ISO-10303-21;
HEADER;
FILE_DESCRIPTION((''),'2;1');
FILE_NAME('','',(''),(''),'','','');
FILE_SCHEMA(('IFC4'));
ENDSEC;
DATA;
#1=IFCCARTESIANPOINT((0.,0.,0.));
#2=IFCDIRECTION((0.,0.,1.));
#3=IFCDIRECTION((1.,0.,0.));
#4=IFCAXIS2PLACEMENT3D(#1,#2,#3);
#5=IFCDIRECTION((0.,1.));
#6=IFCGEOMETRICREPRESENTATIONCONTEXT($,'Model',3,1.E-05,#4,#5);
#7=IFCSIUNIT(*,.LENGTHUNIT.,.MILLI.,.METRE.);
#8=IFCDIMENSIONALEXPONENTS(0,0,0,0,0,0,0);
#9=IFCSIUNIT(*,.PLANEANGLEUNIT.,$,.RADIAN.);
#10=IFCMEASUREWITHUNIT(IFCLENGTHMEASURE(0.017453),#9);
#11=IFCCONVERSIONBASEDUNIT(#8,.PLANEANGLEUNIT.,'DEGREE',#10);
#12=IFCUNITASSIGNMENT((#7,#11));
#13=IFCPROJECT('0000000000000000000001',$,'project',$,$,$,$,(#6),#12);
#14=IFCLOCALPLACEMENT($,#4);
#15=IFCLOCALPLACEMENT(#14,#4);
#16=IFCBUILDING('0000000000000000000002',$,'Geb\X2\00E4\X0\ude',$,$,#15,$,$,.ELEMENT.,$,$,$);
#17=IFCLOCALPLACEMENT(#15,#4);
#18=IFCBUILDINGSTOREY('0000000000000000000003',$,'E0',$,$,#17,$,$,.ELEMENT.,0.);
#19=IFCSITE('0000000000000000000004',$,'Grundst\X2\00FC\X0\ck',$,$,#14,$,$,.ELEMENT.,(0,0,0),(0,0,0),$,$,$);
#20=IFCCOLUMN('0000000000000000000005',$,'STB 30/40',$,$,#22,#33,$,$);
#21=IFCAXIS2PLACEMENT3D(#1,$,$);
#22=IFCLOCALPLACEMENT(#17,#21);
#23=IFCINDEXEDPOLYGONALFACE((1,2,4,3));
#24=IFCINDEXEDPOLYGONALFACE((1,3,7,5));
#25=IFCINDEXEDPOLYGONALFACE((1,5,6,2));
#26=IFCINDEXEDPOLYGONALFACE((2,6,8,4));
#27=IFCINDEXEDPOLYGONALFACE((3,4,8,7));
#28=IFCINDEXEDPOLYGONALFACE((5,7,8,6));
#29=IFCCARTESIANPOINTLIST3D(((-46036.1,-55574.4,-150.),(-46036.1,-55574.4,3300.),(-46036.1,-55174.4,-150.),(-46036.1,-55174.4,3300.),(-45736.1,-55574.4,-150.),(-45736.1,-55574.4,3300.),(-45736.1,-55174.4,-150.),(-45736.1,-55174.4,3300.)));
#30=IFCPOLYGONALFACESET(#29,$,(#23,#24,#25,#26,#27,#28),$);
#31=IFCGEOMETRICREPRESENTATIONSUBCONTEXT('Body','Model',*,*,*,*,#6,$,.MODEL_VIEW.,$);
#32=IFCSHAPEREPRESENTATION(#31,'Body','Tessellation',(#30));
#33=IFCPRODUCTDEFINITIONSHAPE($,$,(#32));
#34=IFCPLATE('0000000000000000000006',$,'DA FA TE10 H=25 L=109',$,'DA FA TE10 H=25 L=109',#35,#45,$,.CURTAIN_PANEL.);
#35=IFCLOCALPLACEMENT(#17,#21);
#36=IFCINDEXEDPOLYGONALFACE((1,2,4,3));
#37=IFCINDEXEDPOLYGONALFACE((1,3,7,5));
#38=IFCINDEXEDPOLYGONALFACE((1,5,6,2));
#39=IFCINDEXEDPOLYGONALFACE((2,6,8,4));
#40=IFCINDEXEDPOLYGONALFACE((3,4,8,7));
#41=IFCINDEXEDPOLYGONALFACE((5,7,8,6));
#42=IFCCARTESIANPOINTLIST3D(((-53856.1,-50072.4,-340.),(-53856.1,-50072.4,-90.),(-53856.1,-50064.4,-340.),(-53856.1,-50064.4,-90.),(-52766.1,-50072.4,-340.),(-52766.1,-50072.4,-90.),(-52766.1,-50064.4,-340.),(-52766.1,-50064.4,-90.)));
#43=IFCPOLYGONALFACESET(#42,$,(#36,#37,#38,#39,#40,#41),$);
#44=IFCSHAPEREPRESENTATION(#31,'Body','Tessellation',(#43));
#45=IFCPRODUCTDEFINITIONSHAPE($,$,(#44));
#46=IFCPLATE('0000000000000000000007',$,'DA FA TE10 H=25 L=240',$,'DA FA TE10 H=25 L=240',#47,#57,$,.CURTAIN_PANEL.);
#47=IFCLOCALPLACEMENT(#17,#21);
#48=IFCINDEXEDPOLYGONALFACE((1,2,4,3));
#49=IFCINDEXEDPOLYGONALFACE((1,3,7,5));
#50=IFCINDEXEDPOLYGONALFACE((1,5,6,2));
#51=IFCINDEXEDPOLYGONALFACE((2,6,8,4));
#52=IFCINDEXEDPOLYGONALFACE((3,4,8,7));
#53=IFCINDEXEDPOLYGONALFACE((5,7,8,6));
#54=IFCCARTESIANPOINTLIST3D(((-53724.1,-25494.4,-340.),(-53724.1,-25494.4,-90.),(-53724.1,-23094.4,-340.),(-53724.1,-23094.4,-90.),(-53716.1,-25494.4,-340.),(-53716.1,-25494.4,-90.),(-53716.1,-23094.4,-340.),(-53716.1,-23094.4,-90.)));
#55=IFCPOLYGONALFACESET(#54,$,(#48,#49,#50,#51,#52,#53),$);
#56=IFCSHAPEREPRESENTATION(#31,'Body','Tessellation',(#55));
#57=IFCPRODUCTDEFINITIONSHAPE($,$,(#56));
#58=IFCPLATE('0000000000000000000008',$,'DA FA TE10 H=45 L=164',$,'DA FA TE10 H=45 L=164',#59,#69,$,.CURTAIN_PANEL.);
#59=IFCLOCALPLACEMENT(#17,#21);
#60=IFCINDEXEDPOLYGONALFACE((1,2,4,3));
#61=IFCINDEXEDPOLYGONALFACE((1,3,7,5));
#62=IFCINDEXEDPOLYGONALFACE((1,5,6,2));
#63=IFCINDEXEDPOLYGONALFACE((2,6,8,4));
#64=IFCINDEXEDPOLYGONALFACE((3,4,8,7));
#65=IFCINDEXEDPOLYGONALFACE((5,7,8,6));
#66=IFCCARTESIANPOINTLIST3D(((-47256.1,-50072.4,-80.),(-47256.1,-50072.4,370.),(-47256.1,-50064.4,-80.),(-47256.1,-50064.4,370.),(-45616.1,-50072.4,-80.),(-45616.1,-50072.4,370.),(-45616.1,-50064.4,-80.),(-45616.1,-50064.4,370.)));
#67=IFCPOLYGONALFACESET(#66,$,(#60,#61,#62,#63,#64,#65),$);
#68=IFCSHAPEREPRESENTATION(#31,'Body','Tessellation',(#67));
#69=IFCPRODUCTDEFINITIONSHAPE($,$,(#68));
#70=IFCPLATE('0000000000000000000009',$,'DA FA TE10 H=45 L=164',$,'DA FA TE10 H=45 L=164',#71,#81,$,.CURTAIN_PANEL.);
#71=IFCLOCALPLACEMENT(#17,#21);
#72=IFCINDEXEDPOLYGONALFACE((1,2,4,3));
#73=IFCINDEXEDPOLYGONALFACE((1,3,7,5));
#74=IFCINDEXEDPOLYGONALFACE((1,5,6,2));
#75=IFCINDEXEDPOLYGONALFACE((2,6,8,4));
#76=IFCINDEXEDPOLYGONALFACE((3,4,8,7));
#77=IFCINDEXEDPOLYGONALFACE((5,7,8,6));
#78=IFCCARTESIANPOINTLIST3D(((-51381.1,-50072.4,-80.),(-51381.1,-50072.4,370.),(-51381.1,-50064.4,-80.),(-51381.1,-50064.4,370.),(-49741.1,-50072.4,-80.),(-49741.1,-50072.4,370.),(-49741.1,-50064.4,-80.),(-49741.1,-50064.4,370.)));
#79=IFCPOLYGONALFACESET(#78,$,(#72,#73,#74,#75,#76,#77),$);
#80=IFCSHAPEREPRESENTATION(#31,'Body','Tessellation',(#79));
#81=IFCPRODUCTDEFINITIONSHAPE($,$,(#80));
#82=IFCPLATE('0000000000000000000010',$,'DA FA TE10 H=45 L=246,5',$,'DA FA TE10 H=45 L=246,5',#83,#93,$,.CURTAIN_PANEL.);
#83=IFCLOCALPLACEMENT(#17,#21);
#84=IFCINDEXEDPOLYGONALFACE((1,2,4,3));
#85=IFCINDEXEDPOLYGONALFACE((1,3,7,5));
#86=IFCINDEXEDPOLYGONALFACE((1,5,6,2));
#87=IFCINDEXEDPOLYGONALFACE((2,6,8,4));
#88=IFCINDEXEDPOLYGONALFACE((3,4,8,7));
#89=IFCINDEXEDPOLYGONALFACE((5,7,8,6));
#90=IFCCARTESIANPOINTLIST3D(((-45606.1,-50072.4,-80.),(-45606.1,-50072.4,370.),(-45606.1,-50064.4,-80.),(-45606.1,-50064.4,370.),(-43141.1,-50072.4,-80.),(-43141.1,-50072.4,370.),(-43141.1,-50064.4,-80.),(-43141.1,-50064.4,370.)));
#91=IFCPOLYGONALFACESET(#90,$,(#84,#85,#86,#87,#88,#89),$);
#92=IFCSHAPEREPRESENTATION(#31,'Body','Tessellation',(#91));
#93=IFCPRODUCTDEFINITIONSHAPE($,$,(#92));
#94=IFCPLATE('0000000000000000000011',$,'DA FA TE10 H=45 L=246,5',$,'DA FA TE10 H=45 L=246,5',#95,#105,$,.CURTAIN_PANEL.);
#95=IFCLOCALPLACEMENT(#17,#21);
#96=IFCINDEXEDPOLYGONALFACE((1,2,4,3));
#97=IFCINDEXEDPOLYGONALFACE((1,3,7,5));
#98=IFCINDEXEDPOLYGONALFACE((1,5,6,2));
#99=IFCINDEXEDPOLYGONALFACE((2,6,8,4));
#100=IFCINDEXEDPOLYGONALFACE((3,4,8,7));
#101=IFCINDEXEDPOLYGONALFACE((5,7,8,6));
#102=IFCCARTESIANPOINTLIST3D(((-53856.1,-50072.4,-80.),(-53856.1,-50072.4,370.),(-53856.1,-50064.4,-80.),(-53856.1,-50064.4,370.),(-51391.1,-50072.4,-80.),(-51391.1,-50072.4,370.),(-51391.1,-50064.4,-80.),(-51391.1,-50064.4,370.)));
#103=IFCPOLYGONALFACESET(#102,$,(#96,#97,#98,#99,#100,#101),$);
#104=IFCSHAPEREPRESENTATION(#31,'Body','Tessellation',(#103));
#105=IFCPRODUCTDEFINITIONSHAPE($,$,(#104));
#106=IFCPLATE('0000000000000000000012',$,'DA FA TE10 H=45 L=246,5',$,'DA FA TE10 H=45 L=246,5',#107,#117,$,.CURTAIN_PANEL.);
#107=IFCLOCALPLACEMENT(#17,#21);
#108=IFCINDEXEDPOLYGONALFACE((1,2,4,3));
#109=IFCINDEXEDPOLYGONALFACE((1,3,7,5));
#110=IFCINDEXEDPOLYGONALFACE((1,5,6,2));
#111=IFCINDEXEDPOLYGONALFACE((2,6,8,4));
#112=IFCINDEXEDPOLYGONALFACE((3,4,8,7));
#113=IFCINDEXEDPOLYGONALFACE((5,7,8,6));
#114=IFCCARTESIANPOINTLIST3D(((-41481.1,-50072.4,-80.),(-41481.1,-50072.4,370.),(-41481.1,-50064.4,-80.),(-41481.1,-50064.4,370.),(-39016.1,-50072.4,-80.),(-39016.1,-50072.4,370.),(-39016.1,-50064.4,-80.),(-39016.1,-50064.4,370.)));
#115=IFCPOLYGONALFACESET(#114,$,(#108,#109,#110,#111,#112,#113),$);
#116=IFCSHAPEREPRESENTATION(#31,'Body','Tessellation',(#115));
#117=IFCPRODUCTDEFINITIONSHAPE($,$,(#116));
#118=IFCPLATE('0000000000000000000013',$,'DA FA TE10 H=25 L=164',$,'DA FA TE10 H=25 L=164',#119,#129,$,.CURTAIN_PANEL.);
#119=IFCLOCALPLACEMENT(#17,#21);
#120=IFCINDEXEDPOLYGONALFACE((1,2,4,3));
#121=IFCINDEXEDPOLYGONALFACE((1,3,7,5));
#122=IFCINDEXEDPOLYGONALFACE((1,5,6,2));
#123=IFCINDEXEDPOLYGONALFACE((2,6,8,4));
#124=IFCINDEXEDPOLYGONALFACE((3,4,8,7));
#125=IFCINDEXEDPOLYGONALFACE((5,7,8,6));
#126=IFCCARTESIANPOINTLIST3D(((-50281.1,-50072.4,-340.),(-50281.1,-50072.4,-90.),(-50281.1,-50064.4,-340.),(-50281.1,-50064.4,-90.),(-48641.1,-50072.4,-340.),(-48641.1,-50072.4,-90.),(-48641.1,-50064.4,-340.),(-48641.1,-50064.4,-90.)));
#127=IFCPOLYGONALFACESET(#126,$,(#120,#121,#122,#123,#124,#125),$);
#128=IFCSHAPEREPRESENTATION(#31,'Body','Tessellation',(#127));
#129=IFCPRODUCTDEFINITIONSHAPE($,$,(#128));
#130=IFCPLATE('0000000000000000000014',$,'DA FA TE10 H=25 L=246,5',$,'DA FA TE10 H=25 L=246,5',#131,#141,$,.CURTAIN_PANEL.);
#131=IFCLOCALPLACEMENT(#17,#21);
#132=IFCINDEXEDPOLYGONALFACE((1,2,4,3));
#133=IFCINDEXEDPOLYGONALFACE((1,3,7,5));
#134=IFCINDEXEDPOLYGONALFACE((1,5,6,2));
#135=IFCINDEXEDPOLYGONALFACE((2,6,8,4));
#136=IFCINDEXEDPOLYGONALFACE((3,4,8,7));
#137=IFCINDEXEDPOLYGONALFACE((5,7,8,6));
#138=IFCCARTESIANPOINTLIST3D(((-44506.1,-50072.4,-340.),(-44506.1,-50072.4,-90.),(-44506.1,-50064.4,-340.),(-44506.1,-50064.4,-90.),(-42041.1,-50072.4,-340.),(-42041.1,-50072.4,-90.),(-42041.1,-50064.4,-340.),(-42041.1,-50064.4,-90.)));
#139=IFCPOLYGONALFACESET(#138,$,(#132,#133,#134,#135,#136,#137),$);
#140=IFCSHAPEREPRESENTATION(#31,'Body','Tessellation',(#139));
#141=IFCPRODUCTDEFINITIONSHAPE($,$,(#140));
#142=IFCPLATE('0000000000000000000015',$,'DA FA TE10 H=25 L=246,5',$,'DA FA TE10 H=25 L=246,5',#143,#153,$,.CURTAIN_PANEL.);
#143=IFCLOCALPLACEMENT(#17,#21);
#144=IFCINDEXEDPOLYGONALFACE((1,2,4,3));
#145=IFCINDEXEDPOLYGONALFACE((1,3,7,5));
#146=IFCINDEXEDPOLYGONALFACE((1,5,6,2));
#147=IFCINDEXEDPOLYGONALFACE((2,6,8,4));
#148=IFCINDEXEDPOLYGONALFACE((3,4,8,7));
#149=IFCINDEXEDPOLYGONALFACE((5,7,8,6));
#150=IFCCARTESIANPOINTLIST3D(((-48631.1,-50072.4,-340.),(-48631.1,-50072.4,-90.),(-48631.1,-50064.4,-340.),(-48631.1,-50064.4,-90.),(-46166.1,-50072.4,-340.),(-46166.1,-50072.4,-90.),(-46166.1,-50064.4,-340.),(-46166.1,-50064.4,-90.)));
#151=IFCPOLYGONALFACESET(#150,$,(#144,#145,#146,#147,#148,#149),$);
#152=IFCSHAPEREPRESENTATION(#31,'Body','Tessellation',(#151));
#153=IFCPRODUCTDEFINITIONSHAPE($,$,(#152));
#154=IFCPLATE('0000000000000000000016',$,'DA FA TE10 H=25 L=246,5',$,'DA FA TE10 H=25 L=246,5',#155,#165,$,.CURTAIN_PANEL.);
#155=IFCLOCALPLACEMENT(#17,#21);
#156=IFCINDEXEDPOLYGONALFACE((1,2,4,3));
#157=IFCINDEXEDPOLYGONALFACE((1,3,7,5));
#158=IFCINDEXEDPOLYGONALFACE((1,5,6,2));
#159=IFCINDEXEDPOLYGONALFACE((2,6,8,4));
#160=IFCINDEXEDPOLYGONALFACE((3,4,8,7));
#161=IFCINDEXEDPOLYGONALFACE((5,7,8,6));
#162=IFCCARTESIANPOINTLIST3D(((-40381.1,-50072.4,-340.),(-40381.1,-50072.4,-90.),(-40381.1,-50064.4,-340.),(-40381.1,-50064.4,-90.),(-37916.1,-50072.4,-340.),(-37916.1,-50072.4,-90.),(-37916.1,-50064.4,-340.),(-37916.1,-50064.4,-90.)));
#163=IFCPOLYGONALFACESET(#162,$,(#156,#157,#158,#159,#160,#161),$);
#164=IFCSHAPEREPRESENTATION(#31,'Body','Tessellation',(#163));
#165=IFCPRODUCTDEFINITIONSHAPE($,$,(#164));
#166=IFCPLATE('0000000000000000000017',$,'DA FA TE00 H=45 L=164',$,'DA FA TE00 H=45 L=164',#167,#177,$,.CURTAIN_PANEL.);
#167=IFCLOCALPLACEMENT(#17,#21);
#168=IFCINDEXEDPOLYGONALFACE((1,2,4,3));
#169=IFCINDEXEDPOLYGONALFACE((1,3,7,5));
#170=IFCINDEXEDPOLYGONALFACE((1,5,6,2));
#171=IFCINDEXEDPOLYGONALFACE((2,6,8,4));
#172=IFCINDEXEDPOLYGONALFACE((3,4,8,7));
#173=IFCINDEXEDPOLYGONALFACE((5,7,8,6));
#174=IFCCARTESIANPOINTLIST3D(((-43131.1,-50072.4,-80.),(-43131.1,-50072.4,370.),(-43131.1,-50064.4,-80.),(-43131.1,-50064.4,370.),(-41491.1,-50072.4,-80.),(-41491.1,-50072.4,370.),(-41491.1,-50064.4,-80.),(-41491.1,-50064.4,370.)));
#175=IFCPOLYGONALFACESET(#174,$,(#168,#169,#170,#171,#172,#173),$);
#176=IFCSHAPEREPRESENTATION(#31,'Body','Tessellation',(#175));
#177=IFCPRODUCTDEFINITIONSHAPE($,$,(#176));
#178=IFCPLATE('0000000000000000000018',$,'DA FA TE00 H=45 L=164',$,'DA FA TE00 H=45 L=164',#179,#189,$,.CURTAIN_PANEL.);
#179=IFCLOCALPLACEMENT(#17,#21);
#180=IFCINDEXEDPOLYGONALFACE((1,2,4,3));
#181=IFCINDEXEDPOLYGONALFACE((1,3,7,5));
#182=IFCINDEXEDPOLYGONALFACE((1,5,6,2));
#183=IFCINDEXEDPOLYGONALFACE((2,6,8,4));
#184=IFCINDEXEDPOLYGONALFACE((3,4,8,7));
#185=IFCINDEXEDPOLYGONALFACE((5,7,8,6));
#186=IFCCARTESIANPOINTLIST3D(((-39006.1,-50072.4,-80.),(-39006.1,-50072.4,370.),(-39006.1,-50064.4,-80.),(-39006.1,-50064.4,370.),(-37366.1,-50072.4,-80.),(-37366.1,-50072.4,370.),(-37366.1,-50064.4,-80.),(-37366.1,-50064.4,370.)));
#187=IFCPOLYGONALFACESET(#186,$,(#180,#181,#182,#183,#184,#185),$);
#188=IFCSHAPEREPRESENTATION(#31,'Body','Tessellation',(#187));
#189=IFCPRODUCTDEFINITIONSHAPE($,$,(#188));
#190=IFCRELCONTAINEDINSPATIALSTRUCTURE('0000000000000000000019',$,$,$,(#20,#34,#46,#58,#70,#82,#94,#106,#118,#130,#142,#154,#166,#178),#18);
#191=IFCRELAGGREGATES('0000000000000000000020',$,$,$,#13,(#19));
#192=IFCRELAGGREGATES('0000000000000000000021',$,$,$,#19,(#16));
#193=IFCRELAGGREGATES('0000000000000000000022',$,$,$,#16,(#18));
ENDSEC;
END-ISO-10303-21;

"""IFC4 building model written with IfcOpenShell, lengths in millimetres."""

from ifc_helpers import new_model, entity, si_unit, converted_unit, direction, frame, origin_with_axes, place, context, subcontext, project, spatial, line, indexed_curve, outline, extrude, source, transform, mapped, element, save


model = new_model("IFC4")

# Units and contexts
model_context = context("Model", 3, precision=1e-05, world=origin_with_axes(), true_north=direction((0.0, 1.0)))
body_context = subcontext(model_context, "Body", "Model", "MODEL_VIEW")
ifc_project = project(units=[si_unit("LENGTHUNIT", "METRE", prefix="MILLI"), converted_unit("PLANEANGLEUNIT", "DEGREE", entity("IfcLengthMeasure", 0.017453), si_unit("PLANEANGLEUNIT", "RADIAN"), dimensions=[0, 0, 0, 0, 0, 0, 0])], contexts=[model_context])

# Site, building, storey
site_placement = place(None, origin_with_axes())
site = spatial("IfcSite", under=ifc_project, at=site_placement, Name="Grundstück", CompositionType="ELEMENT", RefLatitude=(0, 0, 0), RefLongitude=(0, 0, 0))
building_placement = place(site_placement, origin_with_axes())
building = spatial("IfcBuilding", under=site, at=building_placement, Name="Gebäude", CompositionType="ELEMENT")
storey_placement = place(building_placement, origin_with_axes())
storey = spatial("IfcBuildingStorey", under=building, at=storey_placement, Name="E0", CompositionType="ELEMENT", Elevation=0.0)

# Column
column_placement = place(storey_placement, frame((-45886.1, -55374.4, -150.0), z_axis=(0.0, 0.0, 1.0), x_axis=(1.0, 0.0, 0.0)))
element("IfcColumn", 1, at=column_placement, inside=storey, Name="STB 30/40", context=body_context, shape_type="SweptSolid", body=[
    extrude(outline(indexed_curve([(-150.0, -200.0), (150.0, -200.0), (150.0, 200.0), (-150.0, 200.0)], segments=[line(1, 2), line(2, 3), line(3, 4), line(4, 1)])), origin_with_axes(), (0.0, 0.0, 1.0), 3450.0),
])

# Plates
shared_shape_1 = source(origin_with_axes(), body_context, "Body", "SweptSolid", [
    extrude(outline(indexed_curve([(-545.0, 0.0), (545.0, 0.0), (545.0, 8.0), (-545.0, 8.0)], segments=[line(1, 2), line(2, 3), line(3, 4), line(4, 1)])), frame((0.0, 0.0, 250.0), z_axis=(0.0, 0.0, 1.0), x_axis=(1.0, 0.0, 0.0)), (0.0, 0.0, -1.0), 250.0),
])
plate_1_placement = place(storey_placement, frame((-53311.1, -50064.4, -340.0), z_axis=(0.0, 0.0, 1.0), x_axis=(-1.0, 0.0, 0.0)))
element("IfcPlate", 2, at=plate_1_placement, inside=storey, Name="DA FA TE10 H=25 L=109", ObjectType="DA FA TE10 H=25 L=109", PredefinedType="CURTAIN_PANEL", context=body_context, shape_type="MappedRepresentation", body=[
    mapped(shared_shape_1, transform((0.0, 0.0, 0.0), x_axis=(1.0, 0.0, 0.0), y_axis=(0.0, 1.0, 0.0), z_axis=(0.0, 0.0, 1.0), scale=1.0)),
])
shared_shape_2 = source(origin_with_axes(), body_context, "Body", "SweptSolid", [
    extrude(outline(indexed_curve([(-1200.0, 0.0), (1200.0, 0.0), (1200.0, 8.0), (-1200.0, 8.0)], segments=[line(1, 2), line(2, 3), line(3, 4), line(4, 1)])), frame((0.0, 0.0, 250.0), z_axis=(0.0, 0.0, 1.0), x_axis=(1.0, 0.0, 0.0)), (0.0, 0.0, -1.0), 250.0),
])
plate_2_placement = place(storey_placement, frame((-53716.1, -24294.4, -340.0), z_axis=(0.0, 0.0, 1.0), x_axis=(0.0, 1.0, 0.0)))
element("IfcPlate", 3, at=plate_2_placement, inside=storey, Name="DA FA TE10 H=25 L=240", ObjectType="DA FA TE10 H=25 L=240", PredefinedType="CURTAIN_PANEL", context=body_context, shape_type="MappedRepresentation", body=[
    mapped(shared_shape_2, transform((0.0, 0.0, 0.0), x_axis=(1.0, 0.0, 0.0), y_axis=(0.0, 1.0, 0.0), z_axis=(0.0, 0.0, 1.0), scale=1.0)),
])
shared_shape_3 = source(origin_with_axes(), body_context, "Body", "SweptSolid", [
    extrude(outline(indexed_curve([(-820.0, 0.0), (820.0, 0.0), (820.0, 8.0), (-820.0, 8.0)], segments=[line(1, 2), line(2, 3), line(3, 4), line(4, 1)])), frame((0.0, 0.0, 450.0), z_axis=(0.0, 0.0, 1.0), x_axis=(1.0, 0.0, 0.0)), (0.0, 0.0, -1.0), 450.0),
])
for number, where, z_axis, x_axis, name in (
    (4, (-46436.1, -50064.4, -80.0), (0.0, 0.0, 1.0), (-1.0, 0.0, 0.0), "DA FA TE10 H=45 L=164"),
    (5, (-50561.1, -50064.4, -80.0), (0.0, 0.0, 1.0), (-1.0, 0.0, 0.0), "DA FA TE10 H=45 L=164"),
):
    element("IfcPlate", number, at=place(storey_placement, frame(where, z_axis=z_axis, x_axis=x_axis)), inside=storey, Name=name, ObjectType="DA FA TE10 H=45 L=164", PredefinedType="CURTAIN_PANEL", context=body_context, shape_type="MappedRepresentation", body=[
        mapped(shared_shape_3, transform((0.0, 0.0, 0.0), x_axis=(1.0, 0.0, 0.0), y_axis=(0.0, 1.0, 0.0), z_axis=(0.0, 0.0, 1.0), scale=1.0)),
    ])
shared_shape_4 = source(origin_with_axes(), body_context, "Body", "SweptSolid", [
    extrude(outline(indexed_curve([(-1232.5, 0.0), (1232.5, 0.0), (1232.5, 8.0), (-1232.5, 8.0)], segments=[line(1, 2), line(2, 3), line(3, 4), line(4, 1)])), frame((0.0, 0.0, 450.0), z_axis=(0.0, 0.0, 1.0), x_axis=(1.0, 0.0, 0.0)), (0.0, 0.0, -1.0), 450.0),
])
for number, where, z_axis, x_axis, name in (
    (6, (-44373.6, -50064.4, -80.0), (0.0, 0.0, 1.0), (-1.0, 0.0, 0.0), "DA FA TE10 H=45 L=246,5"),
    (7, (-52623.6, -50064.4, -80.0), (0.0, 0.0, 1.0), (-1.0, 0.0, 0.0), "DA FA TE10 H=45 L=246,5"),
    (8, (-40248.6, -50064.4, -80.0), (0.0, 0.0, 1.0), (-1.0, 0.0, 0.0), "DA FA TE10 H=45 L=246,5"),
):
    element("IfcPlate", number, at=place(storey_placement, frame(where, z_axis=z_axis, x_axis=x_axis)), inside=storey, Name=name, ObjectType="DA FA TE10 H=45 L=246,5", PredefinedType="CURTAIN_PANEL", context=body_context, shape_type="MappedRepresentation", body=[
        mapped(shared_shape_4, transform((0.0, 0.0, 0.0), x_axis=(1.0, 0.0, 0.0), y_axis=(0.0, 1.0, 0.0), z_axis=(0.0, 0.0, 1.0), scale=1.0)),
    ])
shared_shape_5 = source(origin_with_axes(), body_context, "Body", "SweptSolid", [
    extrude(outline(indexed_curve([(-820.0, 0.0), (820.0, 0.0), (820.0, 8.0), (-820.0, 8.0)], segments=[line(1, 2), line(2, 3), line(3, 4), line(4, 1)])), frame((0.0, 0.0, 250.0), z_axis=(0.0, 0.0, 1.0), x_axis=(1.0, 0.0, 0.0)), (0.0, 0.0, -1.0), 250.0),
])
plate_3_placement = place(storey_placement, frame((-49461.1, -50064.4, -340.0), z_axis=(0.0, 0.0, 1.0), x_axis=(-1.0, 0.0, 0.0)))
element("IfcPlate", 9, at=plate_3_placement, inside=storey, Name="DA FA TE10 H=25 L=164", ObjectType="DA FA TE10 H=25 L=164", PredefinedType="CURTAIN_PANEL", context=body_context, shape_type="MappedRepresentation", body=[
    mapped(shared_shape_5, transform((0.0, 0.0, 0.0), x_axis=(1.0, 0.0, 0.0), y_axis=(0.0, 1.0, 0.0), z_axis=(0.0, 0.0, 1.0), scale=1.0)),
])
shared_shape_6 = source(origin_with_axes(), body_context, "Body", "SweptSolid", [
    extrude(outline(indexed_curve([(-1232.5, 0.0), (1232.5, 0.0), (1232.5, 8.0), (-1232.5, 8.0)], segments=[line(1, 2), line(2, 3), line(3, 4), line(4, 1)])), frame((0.0, 0.0, 250.0), z_axis=(0.0, 0.0, 1.0), x_axis=(1.0, 0.0, 0.0)), (0.0, 0.0, -1.0), 250.0),
])
for number, where, z_axis, x_axis, name in (
    (10, (-43273.6, -50064.4, -340.0), (0.0, 0.0, 1.0), (-1.0, 0.0, 0.0), "DA FA TE10 H=25 L=246,5"),
    (11, (-47398.6, -50064.4, -340.0), (0.0, 0.0, 1.0), (-1.0, 0.0, 0.0), "DA FA TE10 H=25 L=246,5"),
    (12, (-39148.6, -50064.4, -340.0), (0.0, 0.0, 1.0), (-1.0, 0.0, 0.0), "DA FA TE10 H=25 L=246,5"),
):
    element("IfcPlate", number, at=place(storey_placement, frame(where, z_axis=z_axis, x_axis=x_axis)), inside=storey, Name=name, ObjectType="DA FA TE10 H=25 L=246,5", PredefinedType="CURTAIN_PANEL", context=body_context, shape_type="MappedRepresentation", body=[
        mapped(shared_shape_6, transform((0.0, 0.0, 0.0), x_axis=(1.0, 0.0, 0.0), y_axis=(0.0, 1.0, 0.0), z_axis=(0.0, 0.0, 1.0), scale=1.0)),
    ])
shared_shape_7 = source(origin_with_axes(), body_context, "Body", "SweptSolid", [
    extrude(outline(indexed_curve([(-820.0, 0.0), (820.0, 0.0), (820.0, 8.0), (-820.0, 8.0)], segments=[line(1, 2), line(2, 3), line(3, 4), line(4, 1)])), frame((0.0, 0.0, 450.0), z_axis=(0.0, 0.0, 1.0), x_axis=(1.0, 0.0, 0.0)), (0.0, 0.0, -1.0), 450.0),
])
for number, where, z_axis, x_axis, name in (
    (13, (-42311.1, -50064.4, -80.0), (0.0, 0.0, 1.0), (-1.0, 0.0, 0.0), "DA FA TE00 H=45 L=164"),
    (14, (-38186.1, -50064.4, -80.0), (0.0, 0.0, 1.0), (-1.0, 0.0, 0.0), "DA FA TE00 H=45 L=164"),
):
    element("IfcPlate", number, at=place(storey_placement, frame(where, z_axis=z_axis, x_axis=x_axis)), inside=storey, Name=name, ObjectType="DA FA TE00 H=45 L=164", PredefinedType="CURTAIN_PANEL", context=body_context, shape_type="MappedRepresentation", body=[
        mapped(shared_shape_7, transform((0.0, 0.0, 0.0), x_axis=(1.0, 0.0, 0.0), y_axis=(0.0, 1.0, 0.0), z_axis=(0.0, 0.0, 1.0), scale=1.0)),
    ])

save(model, "model.ifc")
